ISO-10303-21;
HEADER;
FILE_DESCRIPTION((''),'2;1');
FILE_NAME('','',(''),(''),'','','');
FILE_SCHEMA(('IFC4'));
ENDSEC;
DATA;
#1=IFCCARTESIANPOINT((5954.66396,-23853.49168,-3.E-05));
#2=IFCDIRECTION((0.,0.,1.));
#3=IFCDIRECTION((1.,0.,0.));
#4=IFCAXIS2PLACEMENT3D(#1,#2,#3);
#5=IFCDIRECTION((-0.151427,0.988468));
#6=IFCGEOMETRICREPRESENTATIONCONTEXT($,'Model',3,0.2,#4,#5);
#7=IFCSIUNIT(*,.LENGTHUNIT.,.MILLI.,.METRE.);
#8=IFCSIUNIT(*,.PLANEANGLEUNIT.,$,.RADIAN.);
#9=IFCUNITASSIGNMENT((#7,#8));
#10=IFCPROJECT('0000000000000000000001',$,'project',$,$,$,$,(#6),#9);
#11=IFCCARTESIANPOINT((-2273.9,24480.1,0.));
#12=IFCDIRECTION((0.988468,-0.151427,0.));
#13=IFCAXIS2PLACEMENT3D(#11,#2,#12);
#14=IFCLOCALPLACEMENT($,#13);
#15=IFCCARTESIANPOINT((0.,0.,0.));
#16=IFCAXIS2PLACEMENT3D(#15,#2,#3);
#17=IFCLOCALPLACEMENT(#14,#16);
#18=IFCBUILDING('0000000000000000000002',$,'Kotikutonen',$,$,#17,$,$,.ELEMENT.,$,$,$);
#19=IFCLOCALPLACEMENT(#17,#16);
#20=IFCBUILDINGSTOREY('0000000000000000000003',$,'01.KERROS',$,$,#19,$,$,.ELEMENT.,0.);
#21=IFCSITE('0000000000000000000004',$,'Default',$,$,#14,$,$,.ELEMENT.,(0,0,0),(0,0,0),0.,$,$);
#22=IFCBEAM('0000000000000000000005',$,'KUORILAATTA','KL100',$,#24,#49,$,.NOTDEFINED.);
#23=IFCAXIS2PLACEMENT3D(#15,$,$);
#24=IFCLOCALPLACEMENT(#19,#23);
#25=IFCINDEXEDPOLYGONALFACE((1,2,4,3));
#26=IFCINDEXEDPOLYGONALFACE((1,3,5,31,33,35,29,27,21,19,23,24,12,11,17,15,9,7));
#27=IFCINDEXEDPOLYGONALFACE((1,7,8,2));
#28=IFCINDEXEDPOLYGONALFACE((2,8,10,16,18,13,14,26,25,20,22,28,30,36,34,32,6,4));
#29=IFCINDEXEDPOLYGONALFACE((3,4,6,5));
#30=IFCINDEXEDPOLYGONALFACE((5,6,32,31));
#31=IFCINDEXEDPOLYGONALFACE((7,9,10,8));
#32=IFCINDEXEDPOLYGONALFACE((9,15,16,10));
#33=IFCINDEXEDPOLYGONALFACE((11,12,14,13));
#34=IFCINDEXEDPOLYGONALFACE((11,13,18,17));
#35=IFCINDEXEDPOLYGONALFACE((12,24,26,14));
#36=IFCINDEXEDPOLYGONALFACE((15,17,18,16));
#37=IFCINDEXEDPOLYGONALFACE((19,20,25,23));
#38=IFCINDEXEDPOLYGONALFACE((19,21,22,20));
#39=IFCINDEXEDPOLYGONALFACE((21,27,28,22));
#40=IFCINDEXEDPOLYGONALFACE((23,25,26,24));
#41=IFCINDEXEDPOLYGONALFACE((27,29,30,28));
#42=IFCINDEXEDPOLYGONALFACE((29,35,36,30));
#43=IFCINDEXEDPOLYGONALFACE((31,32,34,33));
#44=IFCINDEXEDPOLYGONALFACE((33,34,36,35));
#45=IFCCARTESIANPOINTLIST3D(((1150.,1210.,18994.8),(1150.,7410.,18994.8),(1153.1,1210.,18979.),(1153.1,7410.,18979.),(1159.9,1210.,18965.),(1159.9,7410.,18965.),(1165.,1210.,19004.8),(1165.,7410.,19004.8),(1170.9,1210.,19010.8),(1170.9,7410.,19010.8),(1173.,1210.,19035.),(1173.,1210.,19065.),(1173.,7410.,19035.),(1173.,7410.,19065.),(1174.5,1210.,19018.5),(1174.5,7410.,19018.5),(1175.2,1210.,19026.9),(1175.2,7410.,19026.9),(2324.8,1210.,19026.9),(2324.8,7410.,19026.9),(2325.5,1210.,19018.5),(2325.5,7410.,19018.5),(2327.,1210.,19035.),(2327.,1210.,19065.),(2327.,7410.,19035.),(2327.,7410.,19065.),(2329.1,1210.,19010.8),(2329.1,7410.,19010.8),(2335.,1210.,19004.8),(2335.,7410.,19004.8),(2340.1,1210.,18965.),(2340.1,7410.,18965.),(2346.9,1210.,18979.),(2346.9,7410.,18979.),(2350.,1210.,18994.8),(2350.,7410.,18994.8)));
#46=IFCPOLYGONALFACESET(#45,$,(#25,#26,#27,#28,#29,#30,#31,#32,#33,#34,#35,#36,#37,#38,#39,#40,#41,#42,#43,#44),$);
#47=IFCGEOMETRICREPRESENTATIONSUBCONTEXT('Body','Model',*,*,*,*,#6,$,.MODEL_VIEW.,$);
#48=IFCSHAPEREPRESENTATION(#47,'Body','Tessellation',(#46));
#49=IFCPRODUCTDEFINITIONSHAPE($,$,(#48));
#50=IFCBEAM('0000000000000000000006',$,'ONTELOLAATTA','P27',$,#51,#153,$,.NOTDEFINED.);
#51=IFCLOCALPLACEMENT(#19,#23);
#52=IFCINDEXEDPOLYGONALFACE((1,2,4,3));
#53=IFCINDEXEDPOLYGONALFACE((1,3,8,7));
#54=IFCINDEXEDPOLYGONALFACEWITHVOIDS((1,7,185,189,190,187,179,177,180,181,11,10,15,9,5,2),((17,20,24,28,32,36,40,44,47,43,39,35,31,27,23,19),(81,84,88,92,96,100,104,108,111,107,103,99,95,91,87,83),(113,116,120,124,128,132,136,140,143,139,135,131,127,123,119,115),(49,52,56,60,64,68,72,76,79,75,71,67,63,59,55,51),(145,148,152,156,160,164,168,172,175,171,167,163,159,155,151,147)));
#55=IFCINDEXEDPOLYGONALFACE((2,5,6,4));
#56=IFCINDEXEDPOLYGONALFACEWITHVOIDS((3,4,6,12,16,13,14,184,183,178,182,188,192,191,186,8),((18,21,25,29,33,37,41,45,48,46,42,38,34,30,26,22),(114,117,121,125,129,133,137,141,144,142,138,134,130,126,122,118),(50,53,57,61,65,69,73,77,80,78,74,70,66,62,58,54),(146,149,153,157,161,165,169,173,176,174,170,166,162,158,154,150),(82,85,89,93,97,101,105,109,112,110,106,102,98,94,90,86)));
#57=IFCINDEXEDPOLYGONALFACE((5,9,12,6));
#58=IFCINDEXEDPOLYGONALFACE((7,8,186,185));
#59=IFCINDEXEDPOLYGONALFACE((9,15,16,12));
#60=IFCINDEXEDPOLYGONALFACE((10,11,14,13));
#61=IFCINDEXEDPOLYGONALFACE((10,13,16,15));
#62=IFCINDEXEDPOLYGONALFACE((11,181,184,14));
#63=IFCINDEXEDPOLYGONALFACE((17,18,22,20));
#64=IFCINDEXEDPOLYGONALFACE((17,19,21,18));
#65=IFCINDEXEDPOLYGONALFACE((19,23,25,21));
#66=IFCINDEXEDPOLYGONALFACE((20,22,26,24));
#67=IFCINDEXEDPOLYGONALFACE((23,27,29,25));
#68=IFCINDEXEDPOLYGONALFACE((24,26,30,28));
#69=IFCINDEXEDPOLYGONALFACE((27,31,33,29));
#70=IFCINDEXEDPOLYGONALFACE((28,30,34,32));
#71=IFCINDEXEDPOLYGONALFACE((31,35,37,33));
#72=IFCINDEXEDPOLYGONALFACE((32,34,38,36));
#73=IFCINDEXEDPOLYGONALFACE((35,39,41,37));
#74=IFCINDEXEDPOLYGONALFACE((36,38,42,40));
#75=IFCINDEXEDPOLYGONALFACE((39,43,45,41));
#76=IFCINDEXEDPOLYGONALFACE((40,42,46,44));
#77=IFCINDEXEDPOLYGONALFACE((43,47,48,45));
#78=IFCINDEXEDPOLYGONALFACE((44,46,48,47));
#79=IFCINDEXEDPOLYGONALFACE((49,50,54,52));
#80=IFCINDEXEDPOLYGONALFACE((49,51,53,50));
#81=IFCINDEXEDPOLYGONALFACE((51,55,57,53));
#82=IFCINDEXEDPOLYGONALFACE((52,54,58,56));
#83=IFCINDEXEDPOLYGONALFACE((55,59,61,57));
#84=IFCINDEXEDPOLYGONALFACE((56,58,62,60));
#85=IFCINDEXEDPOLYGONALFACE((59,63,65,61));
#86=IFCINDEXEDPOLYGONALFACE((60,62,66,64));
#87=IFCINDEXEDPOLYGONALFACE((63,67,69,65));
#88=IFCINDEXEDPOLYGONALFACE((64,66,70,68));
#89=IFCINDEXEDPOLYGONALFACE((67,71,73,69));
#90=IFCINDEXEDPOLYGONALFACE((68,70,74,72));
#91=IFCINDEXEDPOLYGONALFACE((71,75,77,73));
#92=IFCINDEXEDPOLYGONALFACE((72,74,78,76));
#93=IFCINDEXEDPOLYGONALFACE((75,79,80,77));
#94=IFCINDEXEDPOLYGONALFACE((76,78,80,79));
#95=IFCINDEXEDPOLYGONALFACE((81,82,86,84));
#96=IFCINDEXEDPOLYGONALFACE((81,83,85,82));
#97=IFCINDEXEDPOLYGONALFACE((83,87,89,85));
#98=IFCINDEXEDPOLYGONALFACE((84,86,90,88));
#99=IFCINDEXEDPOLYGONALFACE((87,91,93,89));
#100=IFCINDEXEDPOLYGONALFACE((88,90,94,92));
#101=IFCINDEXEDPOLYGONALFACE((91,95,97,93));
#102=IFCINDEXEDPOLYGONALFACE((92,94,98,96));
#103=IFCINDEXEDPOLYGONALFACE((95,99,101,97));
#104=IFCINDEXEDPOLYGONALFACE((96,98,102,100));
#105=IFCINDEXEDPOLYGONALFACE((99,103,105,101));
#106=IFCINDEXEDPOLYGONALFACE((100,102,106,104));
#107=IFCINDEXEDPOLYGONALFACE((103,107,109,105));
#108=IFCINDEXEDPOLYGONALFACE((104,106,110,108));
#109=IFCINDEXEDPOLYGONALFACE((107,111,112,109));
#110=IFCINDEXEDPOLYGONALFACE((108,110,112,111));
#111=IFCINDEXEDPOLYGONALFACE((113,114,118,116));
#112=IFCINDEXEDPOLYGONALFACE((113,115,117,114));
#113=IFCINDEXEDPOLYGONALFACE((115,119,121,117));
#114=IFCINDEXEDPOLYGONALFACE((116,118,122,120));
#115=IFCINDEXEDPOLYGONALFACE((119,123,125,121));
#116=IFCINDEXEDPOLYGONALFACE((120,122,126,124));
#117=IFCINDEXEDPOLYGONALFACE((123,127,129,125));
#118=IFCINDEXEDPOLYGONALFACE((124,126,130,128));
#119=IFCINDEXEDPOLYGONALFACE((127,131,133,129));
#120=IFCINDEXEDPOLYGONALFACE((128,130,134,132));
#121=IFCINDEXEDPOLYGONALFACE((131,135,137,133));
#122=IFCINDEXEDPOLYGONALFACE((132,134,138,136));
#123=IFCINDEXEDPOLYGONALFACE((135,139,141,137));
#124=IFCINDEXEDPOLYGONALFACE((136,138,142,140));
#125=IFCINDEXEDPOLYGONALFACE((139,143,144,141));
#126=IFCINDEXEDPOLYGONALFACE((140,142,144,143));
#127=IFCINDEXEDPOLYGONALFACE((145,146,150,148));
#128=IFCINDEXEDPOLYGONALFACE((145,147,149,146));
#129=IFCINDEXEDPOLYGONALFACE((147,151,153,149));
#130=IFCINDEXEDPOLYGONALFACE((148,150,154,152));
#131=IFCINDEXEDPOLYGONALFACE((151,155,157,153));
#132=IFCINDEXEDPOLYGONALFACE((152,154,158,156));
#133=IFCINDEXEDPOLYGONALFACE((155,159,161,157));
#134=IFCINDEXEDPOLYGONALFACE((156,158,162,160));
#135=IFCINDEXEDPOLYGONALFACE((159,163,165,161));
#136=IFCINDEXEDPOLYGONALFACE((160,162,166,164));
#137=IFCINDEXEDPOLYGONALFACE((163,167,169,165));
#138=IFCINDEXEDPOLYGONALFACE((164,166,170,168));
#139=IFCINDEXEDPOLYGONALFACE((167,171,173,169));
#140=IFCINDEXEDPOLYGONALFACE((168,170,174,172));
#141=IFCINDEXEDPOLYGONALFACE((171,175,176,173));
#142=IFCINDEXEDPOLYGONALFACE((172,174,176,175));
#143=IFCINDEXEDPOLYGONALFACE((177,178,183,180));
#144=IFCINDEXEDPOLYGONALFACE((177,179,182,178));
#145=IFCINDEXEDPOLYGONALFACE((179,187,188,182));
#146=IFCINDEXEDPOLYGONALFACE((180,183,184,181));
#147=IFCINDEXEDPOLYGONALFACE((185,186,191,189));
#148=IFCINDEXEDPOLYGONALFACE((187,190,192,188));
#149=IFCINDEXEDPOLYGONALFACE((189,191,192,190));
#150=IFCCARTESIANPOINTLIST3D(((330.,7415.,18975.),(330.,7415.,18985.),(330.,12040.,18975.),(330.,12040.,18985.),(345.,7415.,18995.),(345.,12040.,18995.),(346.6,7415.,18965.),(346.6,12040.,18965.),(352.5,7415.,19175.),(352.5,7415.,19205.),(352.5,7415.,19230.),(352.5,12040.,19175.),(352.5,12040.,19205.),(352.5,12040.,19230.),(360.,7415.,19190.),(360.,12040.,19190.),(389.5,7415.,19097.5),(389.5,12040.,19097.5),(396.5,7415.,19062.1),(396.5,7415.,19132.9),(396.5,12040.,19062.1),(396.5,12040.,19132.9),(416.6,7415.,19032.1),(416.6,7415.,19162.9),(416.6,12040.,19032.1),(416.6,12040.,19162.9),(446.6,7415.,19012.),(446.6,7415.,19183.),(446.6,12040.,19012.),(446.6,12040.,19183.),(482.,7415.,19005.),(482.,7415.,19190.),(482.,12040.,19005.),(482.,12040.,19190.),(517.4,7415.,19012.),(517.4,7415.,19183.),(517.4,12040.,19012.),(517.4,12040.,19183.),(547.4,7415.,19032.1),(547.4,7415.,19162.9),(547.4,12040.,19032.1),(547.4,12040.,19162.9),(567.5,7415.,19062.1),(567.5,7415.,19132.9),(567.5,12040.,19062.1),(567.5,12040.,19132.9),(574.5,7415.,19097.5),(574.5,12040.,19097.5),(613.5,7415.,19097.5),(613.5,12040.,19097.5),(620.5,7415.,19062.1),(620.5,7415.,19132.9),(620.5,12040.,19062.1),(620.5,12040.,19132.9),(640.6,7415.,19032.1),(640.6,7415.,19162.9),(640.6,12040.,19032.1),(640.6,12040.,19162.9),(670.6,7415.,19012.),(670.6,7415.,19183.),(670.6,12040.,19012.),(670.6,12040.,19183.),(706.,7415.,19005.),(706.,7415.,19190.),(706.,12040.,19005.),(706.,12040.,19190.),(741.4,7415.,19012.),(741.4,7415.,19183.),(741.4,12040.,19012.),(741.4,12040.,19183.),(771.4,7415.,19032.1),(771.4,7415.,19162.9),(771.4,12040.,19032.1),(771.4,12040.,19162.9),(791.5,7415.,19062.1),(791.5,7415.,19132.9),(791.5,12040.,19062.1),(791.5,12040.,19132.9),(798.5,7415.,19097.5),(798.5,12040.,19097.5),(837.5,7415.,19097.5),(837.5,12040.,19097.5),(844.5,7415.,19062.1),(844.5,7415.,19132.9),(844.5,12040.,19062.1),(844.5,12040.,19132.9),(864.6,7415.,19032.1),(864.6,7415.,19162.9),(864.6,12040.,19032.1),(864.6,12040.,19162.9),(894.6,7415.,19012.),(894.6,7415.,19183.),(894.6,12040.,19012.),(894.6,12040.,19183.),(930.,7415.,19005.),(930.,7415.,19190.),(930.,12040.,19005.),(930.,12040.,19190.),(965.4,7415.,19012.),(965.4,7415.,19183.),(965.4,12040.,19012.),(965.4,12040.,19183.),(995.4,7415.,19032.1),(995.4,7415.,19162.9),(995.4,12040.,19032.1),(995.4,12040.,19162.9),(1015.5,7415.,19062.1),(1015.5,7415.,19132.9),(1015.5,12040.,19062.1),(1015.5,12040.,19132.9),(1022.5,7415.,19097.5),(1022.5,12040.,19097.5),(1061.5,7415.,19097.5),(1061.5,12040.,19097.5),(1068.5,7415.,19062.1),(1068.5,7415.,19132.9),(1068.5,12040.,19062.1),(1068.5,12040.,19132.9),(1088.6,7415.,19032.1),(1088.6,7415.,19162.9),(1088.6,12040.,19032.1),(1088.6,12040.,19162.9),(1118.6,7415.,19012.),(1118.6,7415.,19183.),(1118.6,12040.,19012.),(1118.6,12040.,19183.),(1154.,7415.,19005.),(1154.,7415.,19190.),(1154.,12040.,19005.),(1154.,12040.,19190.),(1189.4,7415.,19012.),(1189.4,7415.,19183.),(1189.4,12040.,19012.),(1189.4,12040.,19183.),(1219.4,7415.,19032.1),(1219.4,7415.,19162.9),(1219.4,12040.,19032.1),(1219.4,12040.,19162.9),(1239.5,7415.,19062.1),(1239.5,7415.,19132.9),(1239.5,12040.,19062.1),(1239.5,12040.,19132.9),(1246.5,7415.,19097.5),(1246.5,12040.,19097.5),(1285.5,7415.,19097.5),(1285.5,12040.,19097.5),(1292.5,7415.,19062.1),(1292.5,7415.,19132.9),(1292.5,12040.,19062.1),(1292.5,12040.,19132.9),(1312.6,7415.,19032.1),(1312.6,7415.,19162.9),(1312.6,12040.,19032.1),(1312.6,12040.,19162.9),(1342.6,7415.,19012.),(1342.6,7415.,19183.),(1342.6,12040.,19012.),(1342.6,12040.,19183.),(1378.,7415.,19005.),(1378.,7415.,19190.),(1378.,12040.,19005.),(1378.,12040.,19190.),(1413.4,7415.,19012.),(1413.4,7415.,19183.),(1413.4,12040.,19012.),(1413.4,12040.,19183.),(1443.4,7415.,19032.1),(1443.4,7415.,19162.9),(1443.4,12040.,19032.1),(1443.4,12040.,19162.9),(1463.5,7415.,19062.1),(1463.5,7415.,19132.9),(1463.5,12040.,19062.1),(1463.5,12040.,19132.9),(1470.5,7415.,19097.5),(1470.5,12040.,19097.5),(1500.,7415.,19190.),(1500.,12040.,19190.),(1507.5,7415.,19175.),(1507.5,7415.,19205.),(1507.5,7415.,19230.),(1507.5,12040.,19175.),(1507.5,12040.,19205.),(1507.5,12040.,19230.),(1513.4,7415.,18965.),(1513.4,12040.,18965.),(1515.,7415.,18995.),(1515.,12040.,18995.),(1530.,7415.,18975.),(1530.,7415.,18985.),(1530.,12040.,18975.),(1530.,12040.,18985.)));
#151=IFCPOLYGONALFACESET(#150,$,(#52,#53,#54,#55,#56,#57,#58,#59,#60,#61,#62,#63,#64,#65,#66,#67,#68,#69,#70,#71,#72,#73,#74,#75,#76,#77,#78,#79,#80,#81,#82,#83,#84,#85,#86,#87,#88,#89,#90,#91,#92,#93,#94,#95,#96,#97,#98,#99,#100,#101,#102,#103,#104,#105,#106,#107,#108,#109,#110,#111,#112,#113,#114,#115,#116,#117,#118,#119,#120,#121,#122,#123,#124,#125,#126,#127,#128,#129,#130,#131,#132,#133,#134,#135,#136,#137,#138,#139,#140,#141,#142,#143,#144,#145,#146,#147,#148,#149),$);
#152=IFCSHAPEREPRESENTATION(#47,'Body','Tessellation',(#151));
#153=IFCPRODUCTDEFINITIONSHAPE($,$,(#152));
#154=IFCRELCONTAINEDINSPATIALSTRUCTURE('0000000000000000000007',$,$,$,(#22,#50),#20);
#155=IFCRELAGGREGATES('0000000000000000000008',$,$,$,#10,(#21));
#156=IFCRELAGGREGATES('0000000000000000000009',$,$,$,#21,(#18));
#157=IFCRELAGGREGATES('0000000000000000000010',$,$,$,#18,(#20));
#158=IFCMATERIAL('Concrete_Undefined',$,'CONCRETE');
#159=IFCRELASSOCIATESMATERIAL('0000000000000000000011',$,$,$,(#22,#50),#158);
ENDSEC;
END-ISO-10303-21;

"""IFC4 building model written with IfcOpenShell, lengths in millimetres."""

from ifc_helpers import new_model, si_unit, direction, frame, origin_with_axes, place, context, subcontext, project, spatial, line, indexed_curve, outline, extrude, material, element, save


model = new_model("IFC4")

# Units and contexts
model_context = context("Model", 3, precision=0.2, world=frame((5954.66396, -23853.49168, -3e-05), z_axis=(0.0, 0.0, 1.0), x_axis=(1.0, 0.0, 0.0)), true_north=direction((-0.151427, 0.988468)))
body_context = subcontext(model_context, "Body", "Model", "MODEL_VIEW")
ifc_project = project(units=[si_unit("LENGTHUNIT", "METRE", prefix="MILLI"), si_unit("PLANEANGLEUNIT", "RADIAN")], contexts=[model_context])

# Site, building, storey
site_placement = place(None, frame((-2273.9, 24480.1, 0.0), z_axis=(0.0, 0.0, 1.0), x_axis=(0.988468, -0.151427, 0.0)))
site = spatial("IfcSite", under=ifc_project, at=site_placement, Name="Default", CompositionType="ELEMENT", RefLatitude=(0, 0, 0), RefLongitude=(0, 0, 0), RefElevation=0.0)
building_placement = place(site_placement, origin_with_axes())
building = spatial("IfcBuilding", under=site, at=building_placement, Name="Kotikutonen", CompositionType="ELEMENT")
storey_placement = place(building_placement, origin_with_axes())
storey = spatial("IfcBuildingStorey", under=building, at=storey_placement, Name="01.KERROS", CompositionType="ELEMENT", Elevation=0.0)

# Shared definitions
ifc_material_1 = material(Name="Concrete_Undefined", Category="CONCRETE")

# Beams
beam_1_placement = place(storey_placement, frame((1750.0, 7410.0, 19015.0), z_axis=(-1.0, 0.0, 0.0), x_axis=(0.0, -1.0, 0.0)))
element("IfcBeam", 1, at=beam_1_placement, inside=storey, material=ifc_material_1, Name="KUORILAATTA", Description="KL100", PredefinedType="NOTDEFINED", context=body_context, shape_type="SolidModel", body=[
    extrude(outline(indexed_curve([(-596.9, -36.0), (-590.1, -50.0), (590.1, -50.0), (596.9, -36.0), (600.0, -20.2), (585.0, -10.2), (579.1, -4.2), (575.5, 3.5), (574.8, 11.9), (577.0, 20.0), (577.0, 50.0), (-577.0, 50.0), (-577.0, 20.0), (-574.8, 11.9), (-575.5, 3.5), (-579.1, -4.2), (-585.0, -10.2), (-600.0, -20.2)], segments=[line(1, 2, 3, 4, 5, 6, 7, 8, 9, 10, 11, 12, 13, 14, 15, 16, 17, 18, 1)])), frame((0.0, 0.0, 0.0), z_axis=(-1.0, 0.0, 0.0), x_axis=(0.0, 0.0, 1.0)), (0.0, 0.0, -1.0), 6200.0),
])
beam_2_placement = place(storey_placement, frame((930.0, 12040.0, 19097.5), z_axis=(-1.0, 0.0, 0.0), x_axis=(0.0, -1.0, 0.0)))
element("IfcBeam", 2, at=beam_2_placement, inside=storey, material=ifc_material_1, Name="ONTELOLAATTA", Description="P27", PredefinedType="NOTDEFINED", context=body_context, shape_type="SolidModel", body=[
    extrude(outline(indexed_curve([(-600.0, -122.5), (-583.4, -132.5), (583.4, -132.5), (600.0, -122.5), (600.0, -112.5), (585.0, -102.5), (577.5, 77.5), (570.0, 92.5), (577.5, 107.5), (577.5, 132.5), (-577.5, 132.5), (-577.5, 107.5), (-570.0, 92.5), (-577.5, 77.5), (-585.0, -102.5), (-600.0, -112.5)], segments=[line(1, 2, 3, 4, 5, 6, 7, 8, 9, 10, 11, 12, 13, 14, 15, 16, 1)]), holes=[indexed_curve([(-448.0, -92.5), (-483.4, -85.5), (-513.4, -65.4), (-533.5, -35.4), (-540.5, 0.0), (-533.5, 35.4), (-513.4, 65.4), (-483.4, 85.5), (-448.0, 92.5), (-412.6, 85.5), (-382.6, 65.4), (-362.5, 35.4), (-355.5, 0.0), (-362.5, -35.4), (-382.6, -65.4), (-412.6, -85.5)], segments=[line(1, 2, 3, 4, 5, 6, 7, 8, 9, 10, 11, 12, 13, 14, 15, 16, 1)]), indexed_curve([(-224.0, -92.5), (-259.4, -85.5), (-289.4, -65.4), (-309.5, -35.4), (-316.5, 0.0), (-309.5, 35.4), (-289.4, 65.4), (-259.4, 85.5), (-224.0, 92.5), (-188.6, 85.5), (-158.6, 65.4), (-138.5, 35.4), (-131.5, 0.0), (-138.5, -35.4), (-158.6, -65.4), (-188.6, -85.5)], segments=[line(1, 2, 3, 4, 5, 6, 7, 8, 9, 10, 11, 12, 13, 14, 15, 16, 1)]), indexed_curve([(0.0, -92.5), (-35.4, -85.5), (-65.4, -65.4), (-85.5, -35.4), (-92.5, 0.0), (-85.5, 35.4), (-65.4, 65.4), (-35.4, 85.5), (0.0, 92.5), (35.4, 85.5), (65.4, 65.4), (85.5, 35.4), (92.5, 0.0), (85.5, -35.4), (65.4, -65.4), (35.4, -85.5)], segments=[line(1, 2, 3, 4, 5, 6, 7, 8, 9, 10, 11, 12, 13, 14, 15, 16, 1)]), indexed_curve([(224.0, -92.5), (188.6, -85.5), (158.6, -65.4), (138.5, -35.4), (131.5, 0.0), (138.5, 35.4), (158.6, 65.4), (188.6, 85.5), (224.0, 92.5), (259.4, 85.5), (289.4, 65.4), (309.5, 35.4), (316.5, 0.0), (309.5, -35.4), (289.4, -65.4), (259.4, -85.5)], segments=[line(1, 2, 3, 4, 5, 6, 7, 8, 9, 10, 11, 12, 13, 14, 15, 16, 1)]), indexed_curve([(448.0, -92.5), (412.6, -85.5), (382.6, -65.4), (362.5, -35.4), (355.5, 0.0), (362.5, 35.4), (382.6, 65.4), (412.6, 85.5), (448.0, 92.5), (483.4, 85.5), (513.4, 65.4), (533.5, 35.4), (540.5, 0.0), (533.5, -35.4), (513.4, -65.4), (483.4, -85.5)], segments=[line(1, 2, 3, 4, 5, 6, 7, 8, 9, 10, 11, 12, 13, 14, 15, 16, 1)])]), frame((0.0, 0.0, 0.0), z_axis=(-1.0, 0.0, 0.0), x_axis=(0.0, 0.0, 1.0)), (0.0, 0.0, -1.0), 4625.0),
])

save(model, "model.ifc")
